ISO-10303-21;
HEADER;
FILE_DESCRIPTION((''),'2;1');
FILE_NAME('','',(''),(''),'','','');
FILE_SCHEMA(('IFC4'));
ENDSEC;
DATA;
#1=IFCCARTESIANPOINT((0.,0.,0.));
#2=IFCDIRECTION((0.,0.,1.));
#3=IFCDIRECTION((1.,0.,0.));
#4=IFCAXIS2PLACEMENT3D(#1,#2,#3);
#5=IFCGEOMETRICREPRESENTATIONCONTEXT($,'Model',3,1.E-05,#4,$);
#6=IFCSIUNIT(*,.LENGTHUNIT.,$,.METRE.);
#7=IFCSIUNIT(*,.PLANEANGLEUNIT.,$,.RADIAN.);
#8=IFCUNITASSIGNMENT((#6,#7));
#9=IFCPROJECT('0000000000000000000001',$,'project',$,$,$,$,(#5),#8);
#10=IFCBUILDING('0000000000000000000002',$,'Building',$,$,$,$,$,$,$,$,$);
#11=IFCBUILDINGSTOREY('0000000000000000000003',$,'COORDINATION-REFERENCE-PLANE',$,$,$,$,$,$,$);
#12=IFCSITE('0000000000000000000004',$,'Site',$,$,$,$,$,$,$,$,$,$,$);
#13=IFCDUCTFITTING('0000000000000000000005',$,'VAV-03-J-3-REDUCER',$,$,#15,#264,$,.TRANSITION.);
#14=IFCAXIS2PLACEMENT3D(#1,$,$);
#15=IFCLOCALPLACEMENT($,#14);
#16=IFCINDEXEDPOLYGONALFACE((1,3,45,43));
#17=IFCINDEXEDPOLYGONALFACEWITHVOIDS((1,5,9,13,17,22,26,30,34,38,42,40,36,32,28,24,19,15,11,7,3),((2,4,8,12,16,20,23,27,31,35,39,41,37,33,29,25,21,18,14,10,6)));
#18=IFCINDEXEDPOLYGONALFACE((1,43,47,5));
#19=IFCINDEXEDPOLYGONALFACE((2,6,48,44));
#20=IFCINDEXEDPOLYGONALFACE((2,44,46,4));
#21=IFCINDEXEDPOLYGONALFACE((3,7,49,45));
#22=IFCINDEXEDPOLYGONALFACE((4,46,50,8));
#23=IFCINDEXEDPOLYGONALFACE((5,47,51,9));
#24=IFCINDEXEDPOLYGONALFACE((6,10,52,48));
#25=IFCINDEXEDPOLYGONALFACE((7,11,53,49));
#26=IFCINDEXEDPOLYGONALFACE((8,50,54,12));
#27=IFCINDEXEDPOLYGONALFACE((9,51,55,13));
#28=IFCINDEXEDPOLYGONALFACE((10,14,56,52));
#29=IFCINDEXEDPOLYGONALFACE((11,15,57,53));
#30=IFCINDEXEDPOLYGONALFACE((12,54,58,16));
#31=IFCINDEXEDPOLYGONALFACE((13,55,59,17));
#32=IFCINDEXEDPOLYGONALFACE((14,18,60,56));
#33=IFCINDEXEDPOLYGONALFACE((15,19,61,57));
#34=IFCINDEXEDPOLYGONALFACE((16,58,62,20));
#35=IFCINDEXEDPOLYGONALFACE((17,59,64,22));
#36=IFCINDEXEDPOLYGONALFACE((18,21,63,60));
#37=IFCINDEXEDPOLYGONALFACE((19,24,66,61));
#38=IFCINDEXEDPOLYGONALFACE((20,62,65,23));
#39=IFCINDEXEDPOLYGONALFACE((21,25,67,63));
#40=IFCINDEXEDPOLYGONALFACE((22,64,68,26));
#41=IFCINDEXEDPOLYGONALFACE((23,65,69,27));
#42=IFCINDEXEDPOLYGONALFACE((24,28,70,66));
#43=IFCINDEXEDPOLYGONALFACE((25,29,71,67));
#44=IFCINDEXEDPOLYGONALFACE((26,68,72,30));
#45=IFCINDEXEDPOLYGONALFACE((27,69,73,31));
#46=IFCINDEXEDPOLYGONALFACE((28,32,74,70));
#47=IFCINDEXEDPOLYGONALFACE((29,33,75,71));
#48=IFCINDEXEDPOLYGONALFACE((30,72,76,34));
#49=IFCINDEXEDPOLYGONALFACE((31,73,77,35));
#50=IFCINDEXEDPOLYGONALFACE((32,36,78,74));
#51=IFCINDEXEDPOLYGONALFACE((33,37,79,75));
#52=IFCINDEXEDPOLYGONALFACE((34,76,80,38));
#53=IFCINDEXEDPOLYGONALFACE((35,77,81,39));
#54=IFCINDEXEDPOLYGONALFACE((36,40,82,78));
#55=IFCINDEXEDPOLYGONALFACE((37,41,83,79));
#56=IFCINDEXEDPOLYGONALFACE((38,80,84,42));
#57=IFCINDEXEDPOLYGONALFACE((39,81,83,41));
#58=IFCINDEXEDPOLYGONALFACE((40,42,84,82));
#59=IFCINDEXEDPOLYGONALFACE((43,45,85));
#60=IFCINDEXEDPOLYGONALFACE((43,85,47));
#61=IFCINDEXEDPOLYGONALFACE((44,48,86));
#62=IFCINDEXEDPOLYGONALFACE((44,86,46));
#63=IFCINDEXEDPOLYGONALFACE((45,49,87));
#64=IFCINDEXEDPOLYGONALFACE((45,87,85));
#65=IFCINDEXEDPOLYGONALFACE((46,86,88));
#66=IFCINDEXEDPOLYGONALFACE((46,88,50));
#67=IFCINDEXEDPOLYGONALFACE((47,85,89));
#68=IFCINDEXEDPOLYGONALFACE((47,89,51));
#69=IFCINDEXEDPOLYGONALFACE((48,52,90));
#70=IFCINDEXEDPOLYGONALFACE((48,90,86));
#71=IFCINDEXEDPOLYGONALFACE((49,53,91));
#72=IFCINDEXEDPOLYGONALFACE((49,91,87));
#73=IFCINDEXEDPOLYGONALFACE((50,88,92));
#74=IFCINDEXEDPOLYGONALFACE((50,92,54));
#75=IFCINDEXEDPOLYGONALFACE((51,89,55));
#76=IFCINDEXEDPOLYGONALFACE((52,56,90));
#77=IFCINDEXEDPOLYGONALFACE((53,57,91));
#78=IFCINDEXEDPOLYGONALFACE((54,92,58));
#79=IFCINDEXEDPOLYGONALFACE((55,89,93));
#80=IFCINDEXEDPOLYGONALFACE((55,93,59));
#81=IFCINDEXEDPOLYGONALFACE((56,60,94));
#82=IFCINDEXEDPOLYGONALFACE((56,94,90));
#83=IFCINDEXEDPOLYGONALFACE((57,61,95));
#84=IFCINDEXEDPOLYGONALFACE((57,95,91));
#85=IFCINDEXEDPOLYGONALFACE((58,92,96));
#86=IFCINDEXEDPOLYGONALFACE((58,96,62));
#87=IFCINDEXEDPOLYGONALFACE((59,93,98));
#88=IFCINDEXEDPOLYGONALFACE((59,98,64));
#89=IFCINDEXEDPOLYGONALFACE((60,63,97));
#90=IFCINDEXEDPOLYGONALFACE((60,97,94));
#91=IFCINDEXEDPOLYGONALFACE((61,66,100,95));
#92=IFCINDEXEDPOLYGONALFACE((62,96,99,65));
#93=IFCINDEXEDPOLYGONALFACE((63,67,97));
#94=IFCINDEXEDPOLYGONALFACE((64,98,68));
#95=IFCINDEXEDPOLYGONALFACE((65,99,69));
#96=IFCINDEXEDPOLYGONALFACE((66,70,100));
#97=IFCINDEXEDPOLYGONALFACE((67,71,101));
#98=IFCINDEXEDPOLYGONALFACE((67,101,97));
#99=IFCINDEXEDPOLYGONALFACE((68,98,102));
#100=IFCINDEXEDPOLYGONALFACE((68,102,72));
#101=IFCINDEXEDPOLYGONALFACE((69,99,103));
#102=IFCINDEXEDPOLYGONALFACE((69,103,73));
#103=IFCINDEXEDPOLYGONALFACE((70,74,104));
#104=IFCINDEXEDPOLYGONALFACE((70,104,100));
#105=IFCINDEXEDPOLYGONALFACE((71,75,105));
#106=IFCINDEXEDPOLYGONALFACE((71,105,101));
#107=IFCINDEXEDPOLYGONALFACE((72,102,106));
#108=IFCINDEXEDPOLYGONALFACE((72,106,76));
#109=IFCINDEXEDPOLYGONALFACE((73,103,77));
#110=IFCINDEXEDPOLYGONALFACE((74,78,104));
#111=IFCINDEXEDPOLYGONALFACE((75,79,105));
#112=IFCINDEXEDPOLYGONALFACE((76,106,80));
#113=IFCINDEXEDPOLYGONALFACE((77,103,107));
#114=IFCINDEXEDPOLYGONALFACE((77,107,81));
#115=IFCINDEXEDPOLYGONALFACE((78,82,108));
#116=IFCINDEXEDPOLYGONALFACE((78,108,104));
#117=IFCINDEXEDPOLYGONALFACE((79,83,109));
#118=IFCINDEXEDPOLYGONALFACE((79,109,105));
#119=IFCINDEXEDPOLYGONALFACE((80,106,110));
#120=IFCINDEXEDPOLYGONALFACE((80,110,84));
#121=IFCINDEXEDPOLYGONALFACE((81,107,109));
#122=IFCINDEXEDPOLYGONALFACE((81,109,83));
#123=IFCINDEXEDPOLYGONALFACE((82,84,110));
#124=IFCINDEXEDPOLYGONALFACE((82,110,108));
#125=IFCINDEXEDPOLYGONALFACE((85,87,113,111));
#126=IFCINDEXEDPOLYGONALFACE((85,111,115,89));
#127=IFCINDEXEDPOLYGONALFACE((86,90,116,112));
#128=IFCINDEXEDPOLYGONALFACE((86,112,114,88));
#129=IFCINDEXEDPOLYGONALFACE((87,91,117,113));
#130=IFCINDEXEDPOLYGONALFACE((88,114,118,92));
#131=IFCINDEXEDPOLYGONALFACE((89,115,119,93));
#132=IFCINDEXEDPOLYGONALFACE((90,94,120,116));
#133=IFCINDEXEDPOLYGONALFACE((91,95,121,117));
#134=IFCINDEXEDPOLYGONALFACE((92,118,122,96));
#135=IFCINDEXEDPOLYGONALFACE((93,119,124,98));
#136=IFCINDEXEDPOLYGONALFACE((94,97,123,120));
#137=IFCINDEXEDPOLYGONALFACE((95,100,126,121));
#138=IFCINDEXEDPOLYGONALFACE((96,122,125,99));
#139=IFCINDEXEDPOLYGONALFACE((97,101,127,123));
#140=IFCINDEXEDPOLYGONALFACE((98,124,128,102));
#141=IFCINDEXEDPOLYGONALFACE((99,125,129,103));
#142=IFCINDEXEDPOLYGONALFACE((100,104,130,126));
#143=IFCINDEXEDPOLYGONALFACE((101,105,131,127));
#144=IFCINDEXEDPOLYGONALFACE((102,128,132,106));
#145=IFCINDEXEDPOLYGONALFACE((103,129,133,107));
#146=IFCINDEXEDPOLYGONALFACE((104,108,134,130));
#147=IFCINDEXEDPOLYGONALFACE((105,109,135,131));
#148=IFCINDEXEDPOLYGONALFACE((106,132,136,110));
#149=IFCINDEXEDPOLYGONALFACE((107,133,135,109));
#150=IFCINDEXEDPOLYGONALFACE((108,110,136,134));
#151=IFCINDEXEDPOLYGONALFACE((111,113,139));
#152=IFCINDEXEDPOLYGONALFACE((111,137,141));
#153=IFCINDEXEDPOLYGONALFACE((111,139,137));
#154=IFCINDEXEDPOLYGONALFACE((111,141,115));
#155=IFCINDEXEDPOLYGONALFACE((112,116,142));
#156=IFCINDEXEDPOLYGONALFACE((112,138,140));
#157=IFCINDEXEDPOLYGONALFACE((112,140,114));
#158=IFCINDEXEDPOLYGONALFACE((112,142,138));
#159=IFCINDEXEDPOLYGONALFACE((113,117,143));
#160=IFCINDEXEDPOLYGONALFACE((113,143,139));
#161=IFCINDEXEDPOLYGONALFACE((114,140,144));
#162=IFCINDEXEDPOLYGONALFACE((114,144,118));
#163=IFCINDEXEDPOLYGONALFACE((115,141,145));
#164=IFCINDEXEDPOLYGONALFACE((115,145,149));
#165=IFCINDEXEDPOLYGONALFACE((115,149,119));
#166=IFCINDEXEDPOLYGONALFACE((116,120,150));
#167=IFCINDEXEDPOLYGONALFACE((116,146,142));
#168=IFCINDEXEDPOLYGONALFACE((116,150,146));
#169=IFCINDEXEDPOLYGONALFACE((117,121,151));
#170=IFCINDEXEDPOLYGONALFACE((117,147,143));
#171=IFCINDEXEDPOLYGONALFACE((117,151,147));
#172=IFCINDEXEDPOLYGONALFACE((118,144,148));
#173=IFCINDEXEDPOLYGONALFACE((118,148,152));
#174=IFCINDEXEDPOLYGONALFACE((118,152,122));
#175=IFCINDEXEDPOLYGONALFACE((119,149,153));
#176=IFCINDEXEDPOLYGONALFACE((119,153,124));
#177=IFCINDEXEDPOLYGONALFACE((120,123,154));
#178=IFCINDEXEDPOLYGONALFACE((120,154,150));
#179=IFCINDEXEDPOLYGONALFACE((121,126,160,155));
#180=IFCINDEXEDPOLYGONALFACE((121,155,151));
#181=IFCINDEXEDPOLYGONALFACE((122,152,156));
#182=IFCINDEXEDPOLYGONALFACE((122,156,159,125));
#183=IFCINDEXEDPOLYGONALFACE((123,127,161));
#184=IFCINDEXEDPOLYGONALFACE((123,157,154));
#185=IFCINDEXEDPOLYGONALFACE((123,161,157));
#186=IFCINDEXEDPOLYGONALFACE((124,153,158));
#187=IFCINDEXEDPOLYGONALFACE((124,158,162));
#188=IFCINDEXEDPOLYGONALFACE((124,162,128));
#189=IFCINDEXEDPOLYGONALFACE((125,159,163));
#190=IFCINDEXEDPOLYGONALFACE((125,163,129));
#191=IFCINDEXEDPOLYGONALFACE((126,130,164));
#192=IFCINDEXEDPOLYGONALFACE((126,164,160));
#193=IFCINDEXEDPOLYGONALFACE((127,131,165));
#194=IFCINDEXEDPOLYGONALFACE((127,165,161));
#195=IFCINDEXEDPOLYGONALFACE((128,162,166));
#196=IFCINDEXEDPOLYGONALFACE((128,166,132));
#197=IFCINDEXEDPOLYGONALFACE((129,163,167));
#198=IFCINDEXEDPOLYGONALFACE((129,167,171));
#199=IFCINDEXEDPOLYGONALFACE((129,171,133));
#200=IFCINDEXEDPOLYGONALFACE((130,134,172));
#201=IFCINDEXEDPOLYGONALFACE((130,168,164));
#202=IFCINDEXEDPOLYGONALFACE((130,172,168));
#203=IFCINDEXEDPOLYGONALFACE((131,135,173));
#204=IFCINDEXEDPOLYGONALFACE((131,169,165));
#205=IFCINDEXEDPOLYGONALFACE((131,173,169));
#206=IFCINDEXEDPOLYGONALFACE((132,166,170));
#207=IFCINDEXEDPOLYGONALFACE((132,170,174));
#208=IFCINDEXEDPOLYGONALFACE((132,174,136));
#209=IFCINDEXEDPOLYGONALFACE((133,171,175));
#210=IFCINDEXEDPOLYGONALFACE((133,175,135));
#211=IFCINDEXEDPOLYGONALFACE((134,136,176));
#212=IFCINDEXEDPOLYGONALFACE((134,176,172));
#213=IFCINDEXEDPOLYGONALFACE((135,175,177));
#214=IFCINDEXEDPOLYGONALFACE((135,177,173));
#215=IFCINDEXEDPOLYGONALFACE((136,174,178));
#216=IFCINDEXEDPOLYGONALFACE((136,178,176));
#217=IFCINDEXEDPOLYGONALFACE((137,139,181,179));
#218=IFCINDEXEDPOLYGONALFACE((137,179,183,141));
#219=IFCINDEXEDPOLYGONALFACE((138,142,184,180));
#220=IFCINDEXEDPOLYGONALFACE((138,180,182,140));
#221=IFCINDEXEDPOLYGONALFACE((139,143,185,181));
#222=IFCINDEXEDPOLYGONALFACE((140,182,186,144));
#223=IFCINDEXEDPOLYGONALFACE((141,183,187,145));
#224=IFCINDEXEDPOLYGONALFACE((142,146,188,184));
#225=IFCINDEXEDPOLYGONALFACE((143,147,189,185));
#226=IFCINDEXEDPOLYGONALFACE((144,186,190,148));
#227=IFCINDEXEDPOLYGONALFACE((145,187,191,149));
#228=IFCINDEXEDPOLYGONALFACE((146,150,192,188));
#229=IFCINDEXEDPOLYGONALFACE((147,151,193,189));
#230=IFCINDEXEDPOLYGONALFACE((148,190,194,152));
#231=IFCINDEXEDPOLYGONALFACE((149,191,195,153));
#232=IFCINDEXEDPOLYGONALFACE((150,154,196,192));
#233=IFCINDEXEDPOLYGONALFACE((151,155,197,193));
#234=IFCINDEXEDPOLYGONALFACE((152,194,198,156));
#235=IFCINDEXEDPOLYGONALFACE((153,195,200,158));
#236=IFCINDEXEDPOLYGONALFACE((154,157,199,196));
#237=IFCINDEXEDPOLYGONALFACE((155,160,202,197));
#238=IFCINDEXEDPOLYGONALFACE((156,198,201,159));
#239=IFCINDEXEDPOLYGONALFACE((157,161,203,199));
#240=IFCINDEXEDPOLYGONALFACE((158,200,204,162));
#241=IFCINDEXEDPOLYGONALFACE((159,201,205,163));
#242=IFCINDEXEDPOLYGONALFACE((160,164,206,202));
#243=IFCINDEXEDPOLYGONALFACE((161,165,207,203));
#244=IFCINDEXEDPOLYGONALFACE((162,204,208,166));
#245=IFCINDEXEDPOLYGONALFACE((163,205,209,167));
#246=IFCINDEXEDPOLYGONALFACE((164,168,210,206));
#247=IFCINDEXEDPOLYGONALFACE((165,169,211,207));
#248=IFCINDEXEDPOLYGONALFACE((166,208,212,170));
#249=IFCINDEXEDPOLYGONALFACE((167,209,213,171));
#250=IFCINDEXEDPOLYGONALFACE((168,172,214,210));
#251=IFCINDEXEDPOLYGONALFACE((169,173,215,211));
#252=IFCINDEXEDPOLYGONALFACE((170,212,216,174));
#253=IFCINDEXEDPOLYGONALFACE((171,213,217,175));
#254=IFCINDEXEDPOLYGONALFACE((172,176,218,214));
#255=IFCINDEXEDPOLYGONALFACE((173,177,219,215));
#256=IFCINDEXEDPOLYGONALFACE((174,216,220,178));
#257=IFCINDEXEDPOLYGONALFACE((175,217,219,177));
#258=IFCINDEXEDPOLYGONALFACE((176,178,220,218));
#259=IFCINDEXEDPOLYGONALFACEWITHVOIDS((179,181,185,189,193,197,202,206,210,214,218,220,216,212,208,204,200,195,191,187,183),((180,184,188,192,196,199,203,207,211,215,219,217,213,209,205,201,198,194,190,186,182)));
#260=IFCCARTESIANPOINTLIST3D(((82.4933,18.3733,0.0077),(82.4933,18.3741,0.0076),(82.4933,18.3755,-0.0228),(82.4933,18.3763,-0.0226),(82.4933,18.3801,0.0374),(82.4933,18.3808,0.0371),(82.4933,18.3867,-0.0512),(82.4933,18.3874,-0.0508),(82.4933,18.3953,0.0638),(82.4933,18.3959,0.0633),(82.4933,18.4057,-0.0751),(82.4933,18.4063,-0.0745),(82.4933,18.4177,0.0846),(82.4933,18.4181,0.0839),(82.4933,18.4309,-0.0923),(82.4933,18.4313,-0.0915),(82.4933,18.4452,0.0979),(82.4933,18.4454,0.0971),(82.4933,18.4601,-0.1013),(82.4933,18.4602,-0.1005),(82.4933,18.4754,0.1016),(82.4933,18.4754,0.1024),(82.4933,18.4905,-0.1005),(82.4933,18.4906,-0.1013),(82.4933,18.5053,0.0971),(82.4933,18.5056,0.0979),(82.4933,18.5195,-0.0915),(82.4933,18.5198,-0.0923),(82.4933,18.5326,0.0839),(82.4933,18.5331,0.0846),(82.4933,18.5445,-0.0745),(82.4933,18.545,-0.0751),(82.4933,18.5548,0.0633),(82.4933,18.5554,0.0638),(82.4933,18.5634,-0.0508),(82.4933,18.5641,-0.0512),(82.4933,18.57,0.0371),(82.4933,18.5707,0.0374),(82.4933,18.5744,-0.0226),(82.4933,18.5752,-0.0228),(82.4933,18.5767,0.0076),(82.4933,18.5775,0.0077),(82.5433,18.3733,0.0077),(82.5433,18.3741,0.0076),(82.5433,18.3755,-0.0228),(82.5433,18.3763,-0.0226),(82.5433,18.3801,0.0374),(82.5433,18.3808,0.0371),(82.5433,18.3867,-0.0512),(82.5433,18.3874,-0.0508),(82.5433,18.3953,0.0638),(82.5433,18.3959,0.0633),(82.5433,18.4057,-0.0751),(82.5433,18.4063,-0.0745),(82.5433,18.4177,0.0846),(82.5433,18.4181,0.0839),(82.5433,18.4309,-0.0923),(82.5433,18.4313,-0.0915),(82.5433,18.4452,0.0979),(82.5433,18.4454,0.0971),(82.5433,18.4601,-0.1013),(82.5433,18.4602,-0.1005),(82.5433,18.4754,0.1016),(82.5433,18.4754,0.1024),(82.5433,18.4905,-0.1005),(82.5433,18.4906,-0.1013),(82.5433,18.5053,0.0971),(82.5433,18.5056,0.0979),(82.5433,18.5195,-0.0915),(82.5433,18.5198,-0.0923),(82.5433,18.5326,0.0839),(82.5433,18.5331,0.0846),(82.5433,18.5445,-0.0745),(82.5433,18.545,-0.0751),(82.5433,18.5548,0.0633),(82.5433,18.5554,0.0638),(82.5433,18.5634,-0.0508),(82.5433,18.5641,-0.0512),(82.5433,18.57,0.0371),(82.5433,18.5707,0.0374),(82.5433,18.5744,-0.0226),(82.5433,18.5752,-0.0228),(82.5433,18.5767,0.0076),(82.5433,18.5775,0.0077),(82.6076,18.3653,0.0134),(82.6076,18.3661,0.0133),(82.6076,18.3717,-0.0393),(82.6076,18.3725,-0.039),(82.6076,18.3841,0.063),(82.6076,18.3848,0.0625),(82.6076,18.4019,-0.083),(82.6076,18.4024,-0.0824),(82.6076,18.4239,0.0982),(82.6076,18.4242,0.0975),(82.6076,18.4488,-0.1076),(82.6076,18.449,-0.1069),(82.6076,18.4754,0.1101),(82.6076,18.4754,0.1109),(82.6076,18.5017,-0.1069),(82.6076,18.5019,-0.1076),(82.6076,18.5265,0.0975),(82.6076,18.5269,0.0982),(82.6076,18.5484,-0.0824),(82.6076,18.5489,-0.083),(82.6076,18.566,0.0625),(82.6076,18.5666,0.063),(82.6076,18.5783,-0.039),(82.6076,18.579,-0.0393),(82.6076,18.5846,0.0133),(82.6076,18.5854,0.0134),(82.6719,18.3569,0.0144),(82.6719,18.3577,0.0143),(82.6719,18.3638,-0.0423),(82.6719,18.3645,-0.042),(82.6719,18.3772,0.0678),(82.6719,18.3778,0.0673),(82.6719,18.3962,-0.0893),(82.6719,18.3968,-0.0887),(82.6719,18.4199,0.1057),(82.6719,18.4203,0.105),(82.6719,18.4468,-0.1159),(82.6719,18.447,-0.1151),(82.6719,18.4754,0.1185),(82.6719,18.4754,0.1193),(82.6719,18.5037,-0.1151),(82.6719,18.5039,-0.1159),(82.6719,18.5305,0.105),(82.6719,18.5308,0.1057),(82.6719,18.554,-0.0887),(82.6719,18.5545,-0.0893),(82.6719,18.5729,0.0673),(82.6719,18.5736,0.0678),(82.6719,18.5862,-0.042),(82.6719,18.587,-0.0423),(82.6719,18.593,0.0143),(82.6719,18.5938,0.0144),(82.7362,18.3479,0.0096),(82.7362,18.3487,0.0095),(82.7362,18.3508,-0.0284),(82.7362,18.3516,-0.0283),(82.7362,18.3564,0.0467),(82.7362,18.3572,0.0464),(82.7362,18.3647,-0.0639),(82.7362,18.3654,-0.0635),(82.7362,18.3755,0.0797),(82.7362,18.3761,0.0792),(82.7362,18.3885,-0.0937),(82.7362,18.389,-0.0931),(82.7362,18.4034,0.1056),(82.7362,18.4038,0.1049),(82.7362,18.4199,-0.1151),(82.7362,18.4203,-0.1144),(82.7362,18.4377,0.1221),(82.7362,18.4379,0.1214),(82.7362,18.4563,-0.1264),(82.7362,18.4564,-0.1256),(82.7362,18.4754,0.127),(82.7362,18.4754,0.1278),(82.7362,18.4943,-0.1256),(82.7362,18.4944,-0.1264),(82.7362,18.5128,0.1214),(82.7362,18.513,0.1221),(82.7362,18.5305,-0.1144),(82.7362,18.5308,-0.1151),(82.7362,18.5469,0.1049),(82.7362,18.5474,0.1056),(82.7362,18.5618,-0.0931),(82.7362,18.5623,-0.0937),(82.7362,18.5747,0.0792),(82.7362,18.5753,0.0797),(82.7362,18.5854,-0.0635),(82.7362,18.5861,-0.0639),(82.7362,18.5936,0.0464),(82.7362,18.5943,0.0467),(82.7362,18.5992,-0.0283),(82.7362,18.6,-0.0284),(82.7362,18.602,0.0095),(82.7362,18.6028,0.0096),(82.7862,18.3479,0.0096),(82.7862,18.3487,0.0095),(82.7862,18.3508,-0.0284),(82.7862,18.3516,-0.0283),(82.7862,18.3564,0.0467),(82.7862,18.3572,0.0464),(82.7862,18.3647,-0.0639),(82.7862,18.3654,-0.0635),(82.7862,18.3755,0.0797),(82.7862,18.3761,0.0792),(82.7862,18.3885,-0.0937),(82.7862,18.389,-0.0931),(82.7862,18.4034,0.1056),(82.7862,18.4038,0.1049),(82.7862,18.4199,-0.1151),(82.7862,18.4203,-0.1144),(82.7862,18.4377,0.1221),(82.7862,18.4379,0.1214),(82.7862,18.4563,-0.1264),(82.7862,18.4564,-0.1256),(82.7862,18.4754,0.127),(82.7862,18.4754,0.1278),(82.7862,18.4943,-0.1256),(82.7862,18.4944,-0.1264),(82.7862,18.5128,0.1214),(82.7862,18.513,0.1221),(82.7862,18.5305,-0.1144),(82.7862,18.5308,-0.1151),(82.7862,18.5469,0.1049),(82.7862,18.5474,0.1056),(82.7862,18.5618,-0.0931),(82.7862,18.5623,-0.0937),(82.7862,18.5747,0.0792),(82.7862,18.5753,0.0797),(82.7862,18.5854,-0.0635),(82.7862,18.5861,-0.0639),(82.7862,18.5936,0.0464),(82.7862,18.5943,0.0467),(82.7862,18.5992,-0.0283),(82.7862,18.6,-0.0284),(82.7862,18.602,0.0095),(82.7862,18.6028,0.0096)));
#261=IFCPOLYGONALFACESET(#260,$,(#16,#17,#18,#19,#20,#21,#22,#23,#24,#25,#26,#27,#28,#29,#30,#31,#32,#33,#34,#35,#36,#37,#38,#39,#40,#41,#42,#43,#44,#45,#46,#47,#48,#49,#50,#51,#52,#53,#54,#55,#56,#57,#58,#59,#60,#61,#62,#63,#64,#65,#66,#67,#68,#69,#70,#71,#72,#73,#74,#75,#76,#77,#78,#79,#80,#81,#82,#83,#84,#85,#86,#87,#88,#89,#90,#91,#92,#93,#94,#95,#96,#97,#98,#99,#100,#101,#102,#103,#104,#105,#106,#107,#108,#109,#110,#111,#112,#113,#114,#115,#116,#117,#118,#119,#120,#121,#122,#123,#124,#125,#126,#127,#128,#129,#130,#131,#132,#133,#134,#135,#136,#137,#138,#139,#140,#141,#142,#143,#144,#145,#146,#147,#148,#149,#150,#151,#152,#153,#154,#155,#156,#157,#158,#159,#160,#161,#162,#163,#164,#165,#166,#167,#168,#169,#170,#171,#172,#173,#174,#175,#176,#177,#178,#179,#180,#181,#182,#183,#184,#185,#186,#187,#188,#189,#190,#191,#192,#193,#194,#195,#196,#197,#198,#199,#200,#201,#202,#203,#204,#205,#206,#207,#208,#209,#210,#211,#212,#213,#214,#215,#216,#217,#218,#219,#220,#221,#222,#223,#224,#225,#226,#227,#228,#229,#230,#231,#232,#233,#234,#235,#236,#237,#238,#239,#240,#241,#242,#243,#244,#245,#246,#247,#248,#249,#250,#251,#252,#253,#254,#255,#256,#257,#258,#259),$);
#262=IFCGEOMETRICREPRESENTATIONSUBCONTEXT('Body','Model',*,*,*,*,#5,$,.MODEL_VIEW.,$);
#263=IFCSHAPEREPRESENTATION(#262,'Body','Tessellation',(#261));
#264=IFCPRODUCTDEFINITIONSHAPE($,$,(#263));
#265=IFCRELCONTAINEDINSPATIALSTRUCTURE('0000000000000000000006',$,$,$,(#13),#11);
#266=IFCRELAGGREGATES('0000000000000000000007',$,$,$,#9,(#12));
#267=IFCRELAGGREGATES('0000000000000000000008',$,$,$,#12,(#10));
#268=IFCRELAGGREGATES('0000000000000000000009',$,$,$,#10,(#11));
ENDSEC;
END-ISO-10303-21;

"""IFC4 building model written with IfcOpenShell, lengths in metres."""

from ifc_helpers import new_model, entity, si_unit, frame, origin_with_axes, place, context, subcontext, project, spatial, element, save


model = new_model("IFC4")

# Units and contexts
model_context = context("Model", 3, precision=1e-05, world=origin_with_axes())
body_context_1 = subcontext(model_context, "Body", "Model", "MODEL_VIEW")
ifc_project = project(units=[si_unit("LENGTHUNIT", "METRE"), si_unit("PLANEANGLEUNIT", "RADIAN")], contexts=[model_context])

# Site, building, storey
site = spatial("IfcSite", under=ifc_project, Name="Site")
building = spatial("IfcBuilding", under=site, Name="Building")
storey = spatial("IfcBuildingStorey", under=building, Name="COORDINATION-REFERENCE-PLANE")

# Duct fitting
for number, where, z_axis, x_axis, name in (
    (1, (82.7862, 18.4754, 0.0), (0.0, -1.0, 0.0), (0.0, 0.0, 1.0), "VAV-03-J-3-REDUCER"),
):
    element("IfcDuctFitting", number, at=place(None, frame(where, z_axis=z_axis, x_axis=x_axis)), inside=storey, Name=name, PredefinedType="TRANSITION", context=body_context_1, shape_type="SweptSolid", body=[
        entity("IfcRevolvedAreaSolid", entity("IfcArbitraryClosedProfileDef", "AREA", None, entity("IfcPolyline", [entity("IfcCartesianPoint", [0.1278, 0.0]), entity("IfcCartesianPoint", [0.1278, 0.05]), entity("IfcCartesianPoint", [0.1024, 0.2429]), entity("IfcCartesianPoint", [0.1024, 0.2929]), entity("IfcCartesianPoint", [0.1016, 0.2929]), entity("IfcCartesianPoint", [0.1016, 0.2429]), entity("IfcCartesianPoint", [0.127, 0.05]), entity("IfcCartesianPoint", [0.127, 0.0]), entity("IfcCartesianPoint", [0.1278, 0.0])])), entity("IfcAxis2Placement3D", entity("IfcCartesianPoint", [0.0, 0.0, 0.0])), entity("IfcAxis1Placement", entity("IfcCartesianPoint", [0.0, 0.0, 0.0]), entity("IfcDirection", [0.0, 1.0, 0.0])), 6.283185),
    ])

save(model, "model.ifc")
